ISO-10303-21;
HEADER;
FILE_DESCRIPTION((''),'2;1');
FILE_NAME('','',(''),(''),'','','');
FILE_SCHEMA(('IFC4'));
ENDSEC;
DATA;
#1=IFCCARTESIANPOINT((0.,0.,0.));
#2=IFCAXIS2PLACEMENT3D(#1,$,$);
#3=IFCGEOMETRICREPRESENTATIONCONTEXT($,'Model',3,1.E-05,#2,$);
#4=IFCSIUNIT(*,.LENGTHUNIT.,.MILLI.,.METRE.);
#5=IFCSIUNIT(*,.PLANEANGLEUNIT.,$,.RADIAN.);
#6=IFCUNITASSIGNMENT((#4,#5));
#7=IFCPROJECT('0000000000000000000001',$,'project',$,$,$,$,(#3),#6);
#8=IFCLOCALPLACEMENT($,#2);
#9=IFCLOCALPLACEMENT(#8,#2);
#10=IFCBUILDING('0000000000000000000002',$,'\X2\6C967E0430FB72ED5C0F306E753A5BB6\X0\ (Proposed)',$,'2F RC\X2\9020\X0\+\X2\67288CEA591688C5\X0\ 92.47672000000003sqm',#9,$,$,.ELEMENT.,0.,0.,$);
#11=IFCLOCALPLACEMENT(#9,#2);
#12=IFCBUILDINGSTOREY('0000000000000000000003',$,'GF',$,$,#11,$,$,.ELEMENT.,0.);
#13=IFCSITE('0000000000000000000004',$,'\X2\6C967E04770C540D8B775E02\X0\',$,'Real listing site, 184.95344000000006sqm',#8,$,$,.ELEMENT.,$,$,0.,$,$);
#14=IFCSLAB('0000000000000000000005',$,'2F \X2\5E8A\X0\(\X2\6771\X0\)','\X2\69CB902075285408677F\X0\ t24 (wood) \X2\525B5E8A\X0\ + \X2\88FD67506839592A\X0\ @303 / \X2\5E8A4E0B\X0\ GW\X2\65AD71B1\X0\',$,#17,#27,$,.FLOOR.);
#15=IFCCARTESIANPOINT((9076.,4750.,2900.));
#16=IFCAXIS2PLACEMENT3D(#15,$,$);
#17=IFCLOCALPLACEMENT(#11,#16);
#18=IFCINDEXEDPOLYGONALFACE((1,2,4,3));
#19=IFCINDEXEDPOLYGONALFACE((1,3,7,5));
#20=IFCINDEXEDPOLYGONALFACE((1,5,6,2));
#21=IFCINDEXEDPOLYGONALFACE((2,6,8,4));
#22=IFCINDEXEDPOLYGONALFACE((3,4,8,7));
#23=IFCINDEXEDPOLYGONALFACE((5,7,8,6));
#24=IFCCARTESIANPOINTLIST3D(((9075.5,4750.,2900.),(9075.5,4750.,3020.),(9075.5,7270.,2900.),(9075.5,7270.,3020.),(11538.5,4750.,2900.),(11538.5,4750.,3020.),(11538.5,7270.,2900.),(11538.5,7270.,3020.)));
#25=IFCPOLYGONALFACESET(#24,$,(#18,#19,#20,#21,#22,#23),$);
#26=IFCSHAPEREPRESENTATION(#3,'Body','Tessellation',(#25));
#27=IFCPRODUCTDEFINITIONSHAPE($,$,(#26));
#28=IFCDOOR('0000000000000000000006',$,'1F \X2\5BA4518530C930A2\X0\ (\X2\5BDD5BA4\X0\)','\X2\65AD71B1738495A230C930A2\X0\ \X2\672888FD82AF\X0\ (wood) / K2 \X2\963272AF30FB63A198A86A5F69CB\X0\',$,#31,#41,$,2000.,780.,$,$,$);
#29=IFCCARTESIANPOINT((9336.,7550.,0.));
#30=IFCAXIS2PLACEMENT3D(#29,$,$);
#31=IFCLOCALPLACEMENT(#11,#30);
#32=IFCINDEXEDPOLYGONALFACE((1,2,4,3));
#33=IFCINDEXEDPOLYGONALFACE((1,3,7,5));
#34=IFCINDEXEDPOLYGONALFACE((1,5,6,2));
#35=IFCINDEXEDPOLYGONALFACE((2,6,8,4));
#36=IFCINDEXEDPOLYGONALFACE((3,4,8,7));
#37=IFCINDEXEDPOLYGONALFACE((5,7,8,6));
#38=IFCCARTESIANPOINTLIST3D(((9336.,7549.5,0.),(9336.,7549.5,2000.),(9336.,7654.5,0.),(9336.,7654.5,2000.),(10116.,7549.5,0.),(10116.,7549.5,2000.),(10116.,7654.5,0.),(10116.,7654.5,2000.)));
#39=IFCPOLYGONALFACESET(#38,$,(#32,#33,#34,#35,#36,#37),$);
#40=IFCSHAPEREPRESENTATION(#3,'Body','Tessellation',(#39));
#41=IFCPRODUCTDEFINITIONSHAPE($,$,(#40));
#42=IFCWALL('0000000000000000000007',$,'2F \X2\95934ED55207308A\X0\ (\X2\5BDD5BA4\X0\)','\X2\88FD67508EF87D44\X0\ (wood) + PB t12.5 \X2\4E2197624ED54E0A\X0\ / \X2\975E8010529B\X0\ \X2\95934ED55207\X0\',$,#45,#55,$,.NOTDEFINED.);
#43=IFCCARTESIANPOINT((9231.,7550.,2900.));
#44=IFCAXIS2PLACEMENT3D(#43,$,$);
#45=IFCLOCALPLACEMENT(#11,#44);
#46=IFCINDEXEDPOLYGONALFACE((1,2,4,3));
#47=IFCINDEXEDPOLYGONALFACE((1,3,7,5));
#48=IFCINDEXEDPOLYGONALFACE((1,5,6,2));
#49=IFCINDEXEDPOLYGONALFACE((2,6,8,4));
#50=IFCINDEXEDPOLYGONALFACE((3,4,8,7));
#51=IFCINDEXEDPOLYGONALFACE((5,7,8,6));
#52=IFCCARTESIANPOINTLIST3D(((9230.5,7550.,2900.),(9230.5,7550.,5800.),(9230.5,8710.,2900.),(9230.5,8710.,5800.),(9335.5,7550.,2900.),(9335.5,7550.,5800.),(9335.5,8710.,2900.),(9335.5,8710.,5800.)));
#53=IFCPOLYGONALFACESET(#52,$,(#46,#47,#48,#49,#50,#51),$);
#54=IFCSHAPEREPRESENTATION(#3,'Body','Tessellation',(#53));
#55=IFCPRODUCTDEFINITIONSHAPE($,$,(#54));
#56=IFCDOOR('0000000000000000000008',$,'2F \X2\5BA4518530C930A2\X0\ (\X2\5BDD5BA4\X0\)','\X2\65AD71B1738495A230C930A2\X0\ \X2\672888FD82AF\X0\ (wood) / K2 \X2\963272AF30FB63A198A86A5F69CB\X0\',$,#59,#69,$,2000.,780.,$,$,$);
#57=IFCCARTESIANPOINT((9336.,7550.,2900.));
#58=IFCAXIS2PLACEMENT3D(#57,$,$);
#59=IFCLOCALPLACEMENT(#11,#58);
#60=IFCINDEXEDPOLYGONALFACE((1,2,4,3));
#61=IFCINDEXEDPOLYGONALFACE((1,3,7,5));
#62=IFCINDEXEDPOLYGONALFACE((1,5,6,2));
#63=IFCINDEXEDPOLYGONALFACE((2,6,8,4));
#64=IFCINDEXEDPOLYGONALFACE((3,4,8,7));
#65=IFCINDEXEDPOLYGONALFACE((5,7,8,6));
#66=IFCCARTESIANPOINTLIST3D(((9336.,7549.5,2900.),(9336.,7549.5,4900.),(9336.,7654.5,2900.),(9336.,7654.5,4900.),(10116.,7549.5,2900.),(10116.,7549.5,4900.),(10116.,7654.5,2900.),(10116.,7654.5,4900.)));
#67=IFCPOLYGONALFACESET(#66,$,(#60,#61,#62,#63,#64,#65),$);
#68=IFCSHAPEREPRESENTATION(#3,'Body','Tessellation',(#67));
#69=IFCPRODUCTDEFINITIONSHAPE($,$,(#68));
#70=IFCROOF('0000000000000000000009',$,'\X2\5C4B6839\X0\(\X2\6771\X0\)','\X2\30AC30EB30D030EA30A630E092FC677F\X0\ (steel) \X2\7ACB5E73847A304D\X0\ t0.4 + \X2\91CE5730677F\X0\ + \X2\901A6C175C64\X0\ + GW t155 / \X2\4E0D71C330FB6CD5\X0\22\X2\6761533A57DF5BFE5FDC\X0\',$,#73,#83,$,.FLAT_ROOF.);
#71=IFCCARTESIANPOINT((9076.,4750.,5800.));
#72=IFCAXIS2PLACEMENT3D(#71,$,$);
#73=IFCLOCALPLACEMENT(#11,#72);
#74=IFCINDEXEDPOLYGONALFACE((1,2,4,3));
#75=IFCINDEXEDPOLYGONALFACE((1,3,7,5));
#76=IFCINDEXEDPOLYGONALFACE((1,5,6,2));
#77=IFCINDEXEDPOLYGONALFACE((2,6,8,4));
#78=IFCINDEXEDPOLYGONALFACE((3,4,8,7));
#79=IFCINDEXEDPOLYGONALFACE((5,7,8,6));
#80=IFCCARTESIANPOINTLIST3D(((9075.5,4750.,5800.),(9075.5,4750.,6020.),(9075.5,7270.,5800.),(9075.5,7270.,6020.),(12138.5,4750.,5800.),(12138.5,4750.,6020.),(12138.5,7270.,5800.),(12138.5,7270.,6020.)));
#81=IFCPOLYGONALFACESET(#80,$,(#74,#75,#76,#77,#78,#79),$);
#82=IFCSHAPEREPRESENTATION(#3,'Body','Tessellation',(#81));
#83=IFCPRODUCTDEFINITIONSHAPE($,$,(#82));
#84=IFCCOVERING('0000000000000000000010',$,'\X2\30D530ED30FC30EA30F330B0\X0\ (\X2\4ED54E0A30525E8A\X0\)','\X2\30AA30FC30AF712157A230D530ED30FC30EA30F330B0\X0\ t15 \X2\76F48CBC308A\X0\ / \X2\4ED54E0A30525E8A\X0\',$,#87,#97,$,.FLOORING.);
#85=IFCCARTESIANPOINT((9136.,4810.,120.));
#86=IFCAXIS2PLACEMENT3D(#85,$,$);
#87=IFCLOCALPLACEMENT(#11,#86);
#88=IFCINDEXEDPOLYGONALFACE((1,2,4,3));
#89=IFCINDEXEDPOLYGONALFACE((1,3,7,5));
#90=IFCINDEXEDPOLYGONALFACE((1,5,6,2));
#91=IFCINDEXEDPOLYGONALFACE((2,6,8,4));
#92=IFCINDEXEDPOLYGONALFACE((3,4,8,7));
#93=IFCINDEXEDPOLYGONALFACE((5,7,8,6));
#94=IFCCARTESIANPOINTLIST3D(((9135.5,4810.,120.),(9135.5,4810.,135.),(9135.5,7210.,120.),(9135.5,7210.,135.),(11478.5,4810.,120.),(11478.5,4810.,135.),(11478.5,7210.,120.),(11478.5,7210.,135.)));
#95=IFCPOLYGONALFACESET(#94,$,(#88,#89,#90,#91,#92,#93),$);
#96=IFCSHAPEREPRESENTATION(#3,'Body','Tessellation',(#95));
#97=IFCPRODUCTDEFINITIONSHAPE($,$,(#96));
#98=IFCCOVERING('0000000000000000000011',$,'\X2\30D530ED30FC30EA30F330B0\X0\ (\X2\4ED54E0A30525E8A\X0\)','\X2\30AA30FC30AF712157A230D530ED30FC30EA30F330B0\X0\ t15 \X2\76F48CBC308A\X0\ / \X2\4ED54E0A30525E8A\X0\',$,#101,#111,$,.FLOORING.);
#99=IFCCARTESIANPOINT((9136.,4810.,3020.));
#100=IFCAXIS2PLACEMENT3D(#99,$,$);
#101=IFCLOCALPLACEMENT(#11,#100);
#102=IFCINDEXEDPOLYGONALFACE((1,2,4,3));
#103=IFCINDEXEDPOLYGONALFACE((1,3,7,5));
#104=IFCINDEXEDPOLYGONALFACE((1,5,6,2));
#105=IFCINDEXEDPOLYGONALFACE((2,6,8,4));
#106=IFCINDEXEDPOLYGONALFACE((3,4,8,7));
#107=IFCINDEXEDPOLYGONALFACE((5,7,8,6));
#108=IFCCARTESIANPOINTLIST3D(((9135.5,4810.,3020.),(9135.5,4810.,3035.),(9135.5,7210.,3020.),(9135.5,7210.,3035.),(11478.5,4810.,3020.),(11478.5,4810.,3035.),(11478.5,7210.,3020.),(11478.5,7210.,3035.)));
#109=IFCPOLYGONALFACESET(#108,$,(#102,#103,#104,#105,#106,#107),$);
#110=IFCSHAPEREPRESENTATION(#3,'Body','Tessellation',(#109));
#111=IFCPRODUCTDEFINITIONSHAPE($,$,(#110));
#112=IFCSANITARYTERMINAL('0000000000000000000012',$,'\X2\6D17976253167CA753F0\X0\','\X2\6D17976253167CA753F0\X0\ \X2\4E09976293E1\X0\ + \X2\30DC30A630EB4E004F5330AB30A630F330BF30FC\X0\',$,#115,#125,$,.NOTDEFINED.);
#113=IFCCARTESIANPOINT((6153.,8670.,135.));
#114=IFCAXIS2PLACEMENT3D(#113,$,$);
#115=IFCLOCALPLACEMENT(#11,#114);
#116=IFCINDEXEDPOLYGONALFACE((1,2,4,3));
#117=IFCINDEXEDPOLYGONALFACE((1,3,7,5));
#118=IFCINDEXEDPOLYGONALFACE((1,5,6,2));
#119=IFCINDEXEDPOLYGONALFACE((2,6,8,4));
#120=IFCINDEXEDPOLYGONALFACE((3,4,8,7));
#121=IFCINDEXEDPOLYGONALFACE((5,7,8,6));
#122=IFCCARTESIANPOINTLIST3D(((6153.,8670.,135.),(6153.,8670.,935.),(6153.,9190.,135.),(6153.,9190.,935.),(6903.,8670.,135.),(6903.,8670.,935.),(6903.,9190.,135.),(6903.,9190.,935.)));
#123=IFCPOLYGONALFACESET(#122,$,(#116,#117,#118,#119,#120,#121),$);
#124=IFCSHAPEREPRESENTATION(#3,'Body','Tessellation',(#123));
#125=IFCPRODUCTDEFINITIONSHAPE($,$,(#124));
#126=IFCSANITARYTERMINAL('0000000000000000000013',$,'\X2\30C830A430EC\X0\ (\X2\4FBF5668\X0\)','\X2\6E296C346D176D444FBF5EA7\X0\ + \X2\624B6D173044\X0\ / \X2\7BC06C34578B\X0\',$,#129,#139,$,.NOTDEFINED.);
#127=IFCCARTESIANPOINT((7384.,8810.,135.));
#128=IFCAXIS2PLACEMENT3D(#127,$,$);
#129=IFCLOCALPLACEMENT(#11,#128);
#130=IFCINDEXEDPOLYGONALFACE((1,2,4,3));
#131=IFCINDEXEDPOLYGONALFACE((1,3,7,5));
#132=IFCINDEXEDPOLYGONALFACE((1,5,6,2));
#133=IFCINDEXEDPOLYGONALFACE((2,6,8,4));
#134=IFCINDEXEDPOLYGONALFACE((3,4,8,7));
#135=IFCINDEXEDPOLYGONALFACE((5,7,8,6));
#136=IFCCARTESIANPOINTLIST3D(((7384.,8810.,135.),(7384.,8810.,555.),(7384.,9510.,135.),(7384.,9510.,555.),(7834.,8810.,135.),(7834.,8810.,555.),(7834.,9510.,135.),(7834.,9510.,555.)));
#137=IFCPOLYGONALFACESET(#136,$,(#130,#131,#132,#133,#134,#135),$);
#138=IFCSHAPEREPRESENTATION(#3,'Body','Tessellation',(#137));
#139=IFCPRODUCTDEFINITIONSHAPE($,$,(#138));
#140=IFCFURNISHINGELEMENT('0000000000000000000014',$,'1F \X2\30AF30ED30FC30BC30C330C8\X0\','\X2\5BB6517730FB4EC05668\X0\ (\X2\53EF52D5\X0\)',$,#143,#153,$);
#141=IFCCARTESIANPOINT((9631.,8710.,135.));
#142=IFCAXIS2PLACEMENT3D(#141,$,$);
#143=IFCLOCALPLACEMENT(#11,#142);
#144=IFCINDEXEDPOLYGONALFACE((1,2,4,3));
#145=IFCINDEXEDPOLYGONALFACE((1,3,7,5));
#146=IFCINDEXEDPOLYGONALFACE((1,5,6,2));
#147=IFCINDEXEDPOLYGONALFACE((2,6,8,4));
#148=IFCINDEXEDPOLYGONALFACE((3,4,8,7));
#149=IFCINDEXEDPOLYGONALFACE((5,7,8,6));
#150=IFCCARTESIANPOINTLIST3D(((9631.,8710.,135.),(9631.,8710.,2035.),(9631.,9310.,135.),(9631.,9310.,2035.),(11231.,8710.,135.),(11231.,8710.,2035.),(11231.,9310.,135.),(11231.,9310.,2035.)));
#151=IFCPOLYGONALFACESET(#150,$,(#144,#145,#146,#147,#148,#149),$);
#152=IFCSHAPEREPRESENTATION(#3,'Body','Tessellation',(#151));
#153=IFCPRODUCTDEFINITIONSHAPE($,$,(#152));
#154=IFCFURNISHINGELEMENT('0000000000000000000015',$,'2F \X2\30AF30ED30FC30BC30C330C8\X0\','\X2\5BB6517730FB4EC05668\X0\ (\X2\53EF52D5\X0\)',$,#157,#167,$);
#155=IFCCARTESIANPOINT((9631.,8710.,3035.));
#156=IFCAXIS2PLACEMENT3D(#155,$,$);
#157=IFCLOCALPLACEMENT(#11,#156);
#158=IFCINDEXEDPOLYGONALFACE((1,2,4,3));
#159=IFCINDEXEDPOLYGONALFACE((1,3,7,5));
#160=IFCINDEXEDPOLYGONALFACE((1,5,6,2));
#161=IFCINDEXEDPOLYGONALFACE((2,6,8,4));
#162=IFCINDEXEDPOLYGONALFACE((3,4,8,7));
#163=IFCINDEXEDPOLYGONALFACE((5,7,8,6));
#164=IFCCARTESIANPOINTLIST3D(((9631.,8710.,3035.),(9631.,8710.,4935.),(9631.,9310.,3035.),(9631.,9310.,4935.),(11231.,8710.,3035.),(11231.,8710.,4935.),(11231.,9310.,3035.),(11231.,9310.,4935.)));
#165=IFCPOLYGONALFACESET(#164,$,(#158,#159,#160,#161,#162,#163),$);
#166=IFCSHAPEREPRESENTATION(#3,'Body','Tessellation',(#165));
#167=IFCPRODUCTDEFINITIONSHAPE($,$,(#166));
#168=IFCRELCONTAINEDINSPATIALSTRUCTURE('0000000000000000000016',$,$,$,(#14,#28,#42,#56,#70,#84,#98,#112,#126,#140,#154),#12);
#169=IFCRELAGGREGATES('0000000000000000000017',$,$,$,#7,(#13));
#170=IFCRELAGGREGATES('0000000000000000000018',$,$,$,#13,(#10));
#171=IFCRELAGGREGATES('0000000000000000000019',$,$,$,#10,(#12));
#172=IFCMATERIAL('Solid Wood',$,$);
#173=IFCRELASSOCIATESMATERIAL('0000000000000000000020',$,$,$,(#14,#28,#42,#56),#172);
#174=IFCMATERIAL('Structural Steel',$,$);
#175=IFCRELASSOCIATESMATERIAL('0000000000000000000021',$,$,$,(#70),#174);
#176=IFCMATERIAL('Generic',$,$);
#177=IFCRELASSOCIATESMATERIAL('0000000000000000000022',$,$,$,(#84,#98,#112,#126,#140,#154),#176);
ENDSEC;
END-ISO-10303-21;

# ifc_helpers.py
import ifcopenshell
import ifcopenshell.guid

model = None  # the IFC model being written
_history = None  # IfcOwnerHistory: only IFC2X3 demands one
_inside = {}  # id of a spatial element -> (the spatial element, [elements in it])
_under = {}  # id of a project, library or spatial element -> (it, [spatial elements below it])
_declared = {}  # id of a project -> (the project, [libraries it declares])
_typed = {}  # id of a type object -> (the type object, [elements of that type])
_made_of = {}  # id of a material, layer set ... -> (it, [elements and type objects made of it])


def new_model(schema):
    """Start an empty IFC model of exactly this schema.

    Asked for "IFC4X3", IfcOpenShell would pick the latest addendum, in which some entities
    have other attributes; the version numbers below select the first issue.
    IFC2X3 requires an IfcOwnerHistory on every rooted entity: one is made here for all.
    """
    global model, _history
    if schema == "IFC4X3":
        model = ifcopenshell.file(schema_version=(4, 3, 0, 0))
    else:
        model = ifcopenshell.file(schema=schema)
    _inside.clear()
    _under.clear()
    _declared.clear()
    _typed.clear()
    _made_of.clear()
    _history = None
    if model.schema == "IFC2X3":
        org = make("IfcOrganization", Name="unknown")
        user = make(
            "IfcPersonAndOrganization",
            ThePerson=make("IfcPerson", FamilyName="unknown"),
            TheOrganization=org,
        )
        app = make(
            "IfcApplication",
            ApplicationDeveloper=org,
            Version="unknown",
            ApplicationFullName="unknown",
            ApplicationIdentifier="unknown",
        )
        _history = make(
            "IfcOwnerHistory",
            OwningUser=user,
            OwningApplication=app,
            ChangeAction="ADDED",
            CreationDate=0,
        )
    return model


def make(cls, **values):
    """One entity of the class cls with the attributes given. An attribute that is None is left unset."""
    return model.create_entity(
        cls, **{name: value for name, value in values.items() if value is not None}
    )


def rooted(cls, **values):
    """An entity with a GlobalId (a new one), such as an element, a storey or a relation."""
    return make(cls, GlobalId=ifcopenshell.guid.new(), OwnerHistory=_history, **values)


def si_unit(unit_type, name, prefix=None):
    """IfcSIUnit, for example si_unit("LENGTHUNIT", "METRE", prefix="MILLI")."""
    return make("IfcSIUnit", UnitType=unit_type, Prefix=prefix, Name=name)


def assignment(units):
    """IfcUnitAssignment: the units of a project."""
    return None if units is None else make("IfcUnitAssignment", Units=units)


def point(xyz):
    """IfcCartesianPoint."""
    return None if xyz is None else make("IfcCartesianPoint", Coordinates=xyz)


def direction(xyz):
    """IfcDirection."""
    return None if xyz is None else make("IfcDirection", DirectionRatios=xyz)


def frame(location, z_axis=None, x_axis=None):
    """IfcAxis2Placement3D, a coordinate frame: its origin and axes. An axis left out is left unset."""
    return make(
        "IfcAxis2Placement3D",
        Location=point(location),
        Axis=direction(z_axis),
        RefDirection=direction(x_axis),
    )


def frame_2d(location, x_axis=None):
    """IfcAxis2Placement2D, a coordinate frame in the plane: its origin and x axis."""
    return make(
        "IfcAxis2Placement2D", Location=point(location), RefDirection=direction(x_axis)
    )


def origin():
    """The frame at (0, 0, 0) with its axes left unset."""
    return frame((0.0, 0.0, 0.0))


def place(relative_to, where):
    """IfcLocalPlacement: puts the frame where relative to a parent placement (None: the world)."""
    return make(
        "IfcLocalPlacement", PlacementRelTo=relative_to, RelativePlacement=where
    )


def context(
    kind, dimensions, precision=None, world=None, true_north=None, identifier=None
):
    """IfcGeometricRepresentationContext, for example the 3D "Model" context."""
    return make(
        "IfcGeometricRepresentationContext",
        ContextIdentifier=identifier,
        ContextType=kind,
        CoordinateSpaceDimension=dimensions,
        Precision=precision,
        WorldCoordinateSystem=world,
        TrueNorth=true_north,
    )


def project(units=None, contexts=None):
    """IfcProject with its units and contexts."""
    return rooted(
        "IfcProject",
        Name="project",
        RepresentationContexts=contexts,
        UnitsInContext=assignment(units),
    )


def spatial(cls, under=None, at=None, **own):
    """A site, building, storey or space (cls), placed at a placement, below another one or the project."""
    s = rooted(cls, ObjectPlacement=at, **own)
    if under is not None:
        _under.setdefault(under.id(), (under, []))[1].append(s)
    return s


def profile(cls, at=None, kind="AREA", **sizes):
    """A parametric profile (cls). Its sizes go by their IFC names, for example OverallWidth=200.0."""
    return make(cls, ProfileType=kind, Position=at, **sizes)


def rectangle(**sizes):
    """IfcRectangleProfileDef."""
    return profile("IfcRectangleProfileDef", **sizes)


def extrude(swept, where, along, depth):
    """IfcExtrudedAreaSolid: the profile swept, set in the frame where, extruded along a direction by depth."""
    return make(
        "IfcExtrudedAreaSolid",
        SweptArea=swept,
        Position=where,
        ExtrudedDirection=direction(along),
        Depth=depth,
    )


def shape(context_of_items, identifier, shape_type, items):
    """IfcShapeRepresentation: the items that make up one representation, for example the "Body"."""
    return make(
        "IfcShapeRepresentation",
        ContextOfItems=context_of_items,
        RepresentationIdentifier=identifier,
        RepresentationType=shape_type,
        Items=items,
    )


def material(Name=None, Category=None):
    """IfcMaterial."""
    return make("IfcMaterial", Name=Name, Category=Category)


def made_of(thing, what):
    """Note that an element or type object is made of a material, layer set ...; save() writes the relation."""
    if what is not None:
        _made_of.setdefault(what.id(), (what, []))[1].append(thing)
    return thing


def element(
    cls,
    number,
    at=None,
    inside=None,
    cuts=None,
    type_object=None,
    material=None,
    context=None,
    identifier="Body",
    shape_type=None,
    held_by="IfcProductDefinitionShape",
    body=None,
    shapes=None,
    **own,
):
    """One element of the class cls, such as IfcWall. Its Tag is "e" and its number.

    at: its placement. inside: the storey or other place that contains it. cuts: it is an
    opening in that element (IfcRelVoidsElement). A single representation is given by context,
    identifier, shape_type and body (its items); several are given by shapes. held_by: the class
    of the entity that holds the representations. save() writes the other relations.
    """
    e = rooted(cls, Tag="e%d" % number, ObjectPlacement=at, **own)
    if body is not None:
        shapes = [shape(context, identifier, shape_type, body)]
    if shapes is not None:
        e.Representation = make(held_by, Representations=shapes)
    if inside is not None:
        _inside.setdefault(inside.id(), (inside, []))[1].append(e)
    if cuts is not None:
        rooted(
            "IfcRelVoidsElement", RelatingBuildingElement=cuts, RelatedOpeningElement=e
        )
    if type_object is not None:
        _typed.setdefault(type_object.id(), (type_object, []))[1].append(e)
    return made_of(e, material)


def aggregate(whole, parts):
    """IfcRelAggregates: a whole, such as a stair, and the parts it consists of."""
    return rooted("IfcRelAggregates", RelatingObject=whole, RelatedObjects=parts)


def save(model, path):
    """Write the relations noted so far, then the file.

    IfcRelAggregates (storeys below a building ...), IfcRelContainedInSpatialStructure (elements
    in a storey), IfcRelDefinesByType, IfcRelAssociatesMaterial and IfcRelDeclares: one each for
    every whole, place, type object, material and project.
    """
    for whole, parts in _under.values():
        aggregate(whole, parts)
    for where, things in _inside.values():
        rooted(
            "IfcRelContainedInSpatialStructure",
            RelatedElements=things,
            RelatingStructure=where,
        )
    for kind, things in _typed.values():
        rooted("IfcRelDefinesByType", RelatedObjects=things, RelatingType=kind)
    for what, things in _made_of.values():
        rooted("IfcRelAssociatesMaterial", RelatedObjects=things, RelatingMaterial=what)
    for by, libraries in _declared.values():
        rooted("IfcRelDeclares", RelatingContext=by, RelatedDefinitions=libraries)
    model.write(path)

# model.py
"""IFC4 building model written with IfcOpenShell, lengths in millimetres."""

from ifc_helpers import new_model, si_unit, frame, frame_2d, origin, place, context, project, spatial, rectangle, extrude, material, element, save


model = new_model("IFC4")

# Units and contexts
model_context = context("Model", 3, precision=1e-05, world=origin())
ifc_project = project(units=[si_unit("LENGTHUNIT", "METRE", prefix="MILLI"), si_unit("PLANEANGLEUNIT", "RADIAN")], contexts=[model_context])

# Site, building, storey
site_placement = place(None, origin())
site = spatial("IfcSite", under=ifc_project, at=site_placement, Name="沖縄県名護市", ObjectType="Real listing site, 184.95344000000006sqm", CompositionType="ELEMENT", RefElevation=0.0)
building_placement = place(site_placement, origin())
building = spatial("IfcBuilding", under=site, at=building_placement, Name="沖縄・狭小の町家 (Proposed)", ObjectType="2F RC造+木質外装 92.47672000000003sqm", CompositionType="ELEMENT", ElevationOfRefHeight=0.0, ElevationOfTerrain=0.0)
storey_placement = place(building_placement, origin())
storey = spatial("IfcBuildingStorey", under=building, at=storey_placement, Name="GF", CompositionType="ELEMENT", Elevation=0.0)

# Slab
ifc_material_1 = material(Name="Solid Wood")
slab_1_placement = place(storey_placement, frame((9076.0, 4750.0, 2900.0)))
element("IfcSlab", 1, at=slab_1_placement, inside=storey, material=ifc_material_1, Name="2F 床(東)", Description="構造用合板 t24 (wood) 剛床 + 製材根太 @303 / 床下 GW断熱", PredefinedType="FLOOR", context=model_context, shape_type="SweptSolid", body=[
    extrude(rectangle(XDim=2463.0, YDim=2520.0, at=frame_2d((1231.0, 1260.0))), frame((9076.0, 4750.0, 2900.0)), (0.0, 0.0, 1.0), 120.0),
])

# Door
door_1_placement = place(storey_placement, frame((9336.0, 7550.0, 0.0)))
element("IfcDoor", 2, at=door_1_placement, inside=storey, material=ifc_material_1, Name="1F 室内ドア (寝室)", Description="断熱玄関ドア 木製芯 (wood) / K2 防犯・採風機構", OverallHeight=2000.0, OverallWidth=780.0, context=model_context, shape_type="SweptSolid", body=[
    extrude(rectangle(XDim=780.0, YDim=105.0, at=frame_2d((390.0, 52.0))), frame((9336.0, 7550.0, 0.0)), (0.0, 0.0, 1.0), 2000.0),
])

# Wall
wall_1_placement = place(storey_placement, frame((9231.0, 7550.0, 2900.0)))
element("IfcWall", 3, at=wall_1_placement, inside=storey, material=ifc_material_1, Name="2F 間仕切り (寝室)", Description="製材軸組 (wood) + PB t12.5 両面仕上 / 非耐力 間仕切", PredefinedType="NOTDEFINED", context=model_context, shape_type="SweptSolid", body=[
    extrude(rectangle(XDim=105.0, YDim=1160.0, at=frame_2d((52.0, 580.0))), frame((9231.0, 7550.0, 2900.0)), (0.0, 0.0, 1.0), 2900.0),
])

# Door
door_2_placement = place(storey_placement, frame((9336.0, 7550.0, 2900.0)))
element("IfcDoor", 4, at=door_2_placement, inside=storey, material=ifc_material_1, Name="2F 室内ドア (寝室)", Description="断熱玄関ドア 木製芯 (wood) / K2 防犯・採風機構", OverallHeight=2000.0, OverallWidth=780.0, context=model_context, shape_type="SweptSolid", body=[
    extrude(rectangle(XDim=780.0, YDim=105.0, at=frame_2d((390.0, 52.0))), frame((9336.0, 7550.0, 2900.0)), (0.0, 0.0, 1.0), 2000.0),
])

# Roof
ifc_material_2 = material(Name="Structural Steel")
for number, where, name in (
    (5, (9076.0, 4750.0, 5800.0), "屋根(東)"),
):
    element("IfcRoof", number, at=place(storey_placement, frame(where)), inside=storey, material=ifc_material_2, Name=name, Description="ガルバリウム鋼板 (steel) 立平葺き t0.4 + 野地板 + 通気層 + GW t155 / 不燃・法22条区域対応", PredefinedType="FLAT_ROOF", context=model_context, shape_type="SweptSolid", body=[
        extrude(rectangle(XDim=3063.0, YDim=2520.0, at=frame_2d((1531.0, 1260.0))), frame((9076.0, 4750.0, 5800.0)), (0.0, 0.0, 1.0), 220.0),
    ])

# Coverings
ifc_material_3 = material(Name="Generic")
covering_1_placement = place(storey_placement, frame((9136.0, 4810.0, 120.0)))
element("IfcCovering", 6, at=covering_1_placement, inside=storey, material=ifc_material_3, Name="フローリング (仕上げ床)", Description="オーク無垢フローリング t15 直貼り / 仕上げ床", PredefinedType="FLOORING", context=model_context, shape_type="SweptSolid", body=[
    extrude(rectangle(XDim=2343.0, YDim=2400.0, at=frame_2d((1171.0, 1200.0))), frame((9136.0, 4810.0, 120.0)), (0.0, 0.0, 1.0), 15.0),
])
covering_2_placement = place(storey_placement, frame((9136.0, 4810.0, 3020.0)))
element("IfcCovering", 7, at=covering_2_placement, inside=storey, material=ifc_material_3, Name="フローリング (仕上げ床)", Description="オーク無垢フローリング t15 直貼り / 仕上げ床", PredefinedType="FLOORING", context=model_context, shape_type="SweptSolid", body=[
    extrude(rectangle(XDim=2343.0, YDim=2400.0, at=frame_2d((1171.0, 1200.0))), frame((9136.0, 4810.0, 3020.0)), (0.0, 0.0, 1.0), 15.0),
])

# Sanitary terminals
sanitary_terminal_1_placement = place(storey_placement, frame((6153.0, 8670.0, 135.0)))
element("IfcSanitaryTerminal", 8, at=sanitary_terminal_1_placement, inside=storey, material=ifc_material_3, Name="洗面化粧台", Description="洗面化粧台 三面鏡 + ボウル一体カウンター", PredefinedType="NOTDEFINED", context=model_context, shape_type="SweptSolid", body=[
    extrude(rectangle(XDim=750.0, YDim=520.0, at=frame_2d((375.0, 260.0))), frame((6153.0, 8670.0, 135.0)), (0.0, 0.0, 1.0), 800.0),
])
sanitary_terminal_2_placement = place(storey_placement, frame((7384.0, 8810.0, 135.0)))
element("IfcSanitaryTerminal", 9, at=sanitary_terminal_2_placement, inside=storey, material=ifc_material_3, Name="トイレ (便器)", Description="温水洗浄便座 + 手洗い / 節水型", PredefinedType="NOTDEFINED", context=model_context, shape_type="SweptSolid", body=[
    extrude(rectangle(XDim=450.0, YDim=700.0, at=frame_2d((225.0, 350.0))), frame((7384.0, 8810.0, 135.0)), (0.0, 0.0, 1.0), 420.0),
])

# Furnishing elements
furnishing_1_placement = place(storey_placement, frame((9631.0, 8710.0, 135.0)))
element("IfcFurnishingElement", 10, at=furnishing_1_placement, inside=storey, material=ifc_material_3, Name="1F クローゼット", Description="家具・什器 (可動)", context=model_context, shape_type="SweptSolid", body=[
    extrude(rectangle(XDim=1600.0, YDim=600.0, at=frame_2d((800.0, 300.0))), frame((9631.0, 8710.0, 135.0)), (0.0, 0.0, 1.0), 1900.0),
])
furnishing_2_placement = place(storey_placement, frame((9631.0, 8710.0, 3035.0)))
element("IfcFurnishingElement", 11, at=furnishing_2_placement, inside=storey, material=ifc_material_3, Name="2F クローゼット", Description="家具・什器 (可動)", context=model_context, shape_type="SweptSolid", body=[
    extrude(rectangle(XDim=1600.0, YDim=600.0, at=frame_2d((800.0, 300.0))), frame((9631.0, 8710.0, 3035.0)), (0.0, 0.0, 1.0), 1900.0),
])

save(model, "model.ifc")
